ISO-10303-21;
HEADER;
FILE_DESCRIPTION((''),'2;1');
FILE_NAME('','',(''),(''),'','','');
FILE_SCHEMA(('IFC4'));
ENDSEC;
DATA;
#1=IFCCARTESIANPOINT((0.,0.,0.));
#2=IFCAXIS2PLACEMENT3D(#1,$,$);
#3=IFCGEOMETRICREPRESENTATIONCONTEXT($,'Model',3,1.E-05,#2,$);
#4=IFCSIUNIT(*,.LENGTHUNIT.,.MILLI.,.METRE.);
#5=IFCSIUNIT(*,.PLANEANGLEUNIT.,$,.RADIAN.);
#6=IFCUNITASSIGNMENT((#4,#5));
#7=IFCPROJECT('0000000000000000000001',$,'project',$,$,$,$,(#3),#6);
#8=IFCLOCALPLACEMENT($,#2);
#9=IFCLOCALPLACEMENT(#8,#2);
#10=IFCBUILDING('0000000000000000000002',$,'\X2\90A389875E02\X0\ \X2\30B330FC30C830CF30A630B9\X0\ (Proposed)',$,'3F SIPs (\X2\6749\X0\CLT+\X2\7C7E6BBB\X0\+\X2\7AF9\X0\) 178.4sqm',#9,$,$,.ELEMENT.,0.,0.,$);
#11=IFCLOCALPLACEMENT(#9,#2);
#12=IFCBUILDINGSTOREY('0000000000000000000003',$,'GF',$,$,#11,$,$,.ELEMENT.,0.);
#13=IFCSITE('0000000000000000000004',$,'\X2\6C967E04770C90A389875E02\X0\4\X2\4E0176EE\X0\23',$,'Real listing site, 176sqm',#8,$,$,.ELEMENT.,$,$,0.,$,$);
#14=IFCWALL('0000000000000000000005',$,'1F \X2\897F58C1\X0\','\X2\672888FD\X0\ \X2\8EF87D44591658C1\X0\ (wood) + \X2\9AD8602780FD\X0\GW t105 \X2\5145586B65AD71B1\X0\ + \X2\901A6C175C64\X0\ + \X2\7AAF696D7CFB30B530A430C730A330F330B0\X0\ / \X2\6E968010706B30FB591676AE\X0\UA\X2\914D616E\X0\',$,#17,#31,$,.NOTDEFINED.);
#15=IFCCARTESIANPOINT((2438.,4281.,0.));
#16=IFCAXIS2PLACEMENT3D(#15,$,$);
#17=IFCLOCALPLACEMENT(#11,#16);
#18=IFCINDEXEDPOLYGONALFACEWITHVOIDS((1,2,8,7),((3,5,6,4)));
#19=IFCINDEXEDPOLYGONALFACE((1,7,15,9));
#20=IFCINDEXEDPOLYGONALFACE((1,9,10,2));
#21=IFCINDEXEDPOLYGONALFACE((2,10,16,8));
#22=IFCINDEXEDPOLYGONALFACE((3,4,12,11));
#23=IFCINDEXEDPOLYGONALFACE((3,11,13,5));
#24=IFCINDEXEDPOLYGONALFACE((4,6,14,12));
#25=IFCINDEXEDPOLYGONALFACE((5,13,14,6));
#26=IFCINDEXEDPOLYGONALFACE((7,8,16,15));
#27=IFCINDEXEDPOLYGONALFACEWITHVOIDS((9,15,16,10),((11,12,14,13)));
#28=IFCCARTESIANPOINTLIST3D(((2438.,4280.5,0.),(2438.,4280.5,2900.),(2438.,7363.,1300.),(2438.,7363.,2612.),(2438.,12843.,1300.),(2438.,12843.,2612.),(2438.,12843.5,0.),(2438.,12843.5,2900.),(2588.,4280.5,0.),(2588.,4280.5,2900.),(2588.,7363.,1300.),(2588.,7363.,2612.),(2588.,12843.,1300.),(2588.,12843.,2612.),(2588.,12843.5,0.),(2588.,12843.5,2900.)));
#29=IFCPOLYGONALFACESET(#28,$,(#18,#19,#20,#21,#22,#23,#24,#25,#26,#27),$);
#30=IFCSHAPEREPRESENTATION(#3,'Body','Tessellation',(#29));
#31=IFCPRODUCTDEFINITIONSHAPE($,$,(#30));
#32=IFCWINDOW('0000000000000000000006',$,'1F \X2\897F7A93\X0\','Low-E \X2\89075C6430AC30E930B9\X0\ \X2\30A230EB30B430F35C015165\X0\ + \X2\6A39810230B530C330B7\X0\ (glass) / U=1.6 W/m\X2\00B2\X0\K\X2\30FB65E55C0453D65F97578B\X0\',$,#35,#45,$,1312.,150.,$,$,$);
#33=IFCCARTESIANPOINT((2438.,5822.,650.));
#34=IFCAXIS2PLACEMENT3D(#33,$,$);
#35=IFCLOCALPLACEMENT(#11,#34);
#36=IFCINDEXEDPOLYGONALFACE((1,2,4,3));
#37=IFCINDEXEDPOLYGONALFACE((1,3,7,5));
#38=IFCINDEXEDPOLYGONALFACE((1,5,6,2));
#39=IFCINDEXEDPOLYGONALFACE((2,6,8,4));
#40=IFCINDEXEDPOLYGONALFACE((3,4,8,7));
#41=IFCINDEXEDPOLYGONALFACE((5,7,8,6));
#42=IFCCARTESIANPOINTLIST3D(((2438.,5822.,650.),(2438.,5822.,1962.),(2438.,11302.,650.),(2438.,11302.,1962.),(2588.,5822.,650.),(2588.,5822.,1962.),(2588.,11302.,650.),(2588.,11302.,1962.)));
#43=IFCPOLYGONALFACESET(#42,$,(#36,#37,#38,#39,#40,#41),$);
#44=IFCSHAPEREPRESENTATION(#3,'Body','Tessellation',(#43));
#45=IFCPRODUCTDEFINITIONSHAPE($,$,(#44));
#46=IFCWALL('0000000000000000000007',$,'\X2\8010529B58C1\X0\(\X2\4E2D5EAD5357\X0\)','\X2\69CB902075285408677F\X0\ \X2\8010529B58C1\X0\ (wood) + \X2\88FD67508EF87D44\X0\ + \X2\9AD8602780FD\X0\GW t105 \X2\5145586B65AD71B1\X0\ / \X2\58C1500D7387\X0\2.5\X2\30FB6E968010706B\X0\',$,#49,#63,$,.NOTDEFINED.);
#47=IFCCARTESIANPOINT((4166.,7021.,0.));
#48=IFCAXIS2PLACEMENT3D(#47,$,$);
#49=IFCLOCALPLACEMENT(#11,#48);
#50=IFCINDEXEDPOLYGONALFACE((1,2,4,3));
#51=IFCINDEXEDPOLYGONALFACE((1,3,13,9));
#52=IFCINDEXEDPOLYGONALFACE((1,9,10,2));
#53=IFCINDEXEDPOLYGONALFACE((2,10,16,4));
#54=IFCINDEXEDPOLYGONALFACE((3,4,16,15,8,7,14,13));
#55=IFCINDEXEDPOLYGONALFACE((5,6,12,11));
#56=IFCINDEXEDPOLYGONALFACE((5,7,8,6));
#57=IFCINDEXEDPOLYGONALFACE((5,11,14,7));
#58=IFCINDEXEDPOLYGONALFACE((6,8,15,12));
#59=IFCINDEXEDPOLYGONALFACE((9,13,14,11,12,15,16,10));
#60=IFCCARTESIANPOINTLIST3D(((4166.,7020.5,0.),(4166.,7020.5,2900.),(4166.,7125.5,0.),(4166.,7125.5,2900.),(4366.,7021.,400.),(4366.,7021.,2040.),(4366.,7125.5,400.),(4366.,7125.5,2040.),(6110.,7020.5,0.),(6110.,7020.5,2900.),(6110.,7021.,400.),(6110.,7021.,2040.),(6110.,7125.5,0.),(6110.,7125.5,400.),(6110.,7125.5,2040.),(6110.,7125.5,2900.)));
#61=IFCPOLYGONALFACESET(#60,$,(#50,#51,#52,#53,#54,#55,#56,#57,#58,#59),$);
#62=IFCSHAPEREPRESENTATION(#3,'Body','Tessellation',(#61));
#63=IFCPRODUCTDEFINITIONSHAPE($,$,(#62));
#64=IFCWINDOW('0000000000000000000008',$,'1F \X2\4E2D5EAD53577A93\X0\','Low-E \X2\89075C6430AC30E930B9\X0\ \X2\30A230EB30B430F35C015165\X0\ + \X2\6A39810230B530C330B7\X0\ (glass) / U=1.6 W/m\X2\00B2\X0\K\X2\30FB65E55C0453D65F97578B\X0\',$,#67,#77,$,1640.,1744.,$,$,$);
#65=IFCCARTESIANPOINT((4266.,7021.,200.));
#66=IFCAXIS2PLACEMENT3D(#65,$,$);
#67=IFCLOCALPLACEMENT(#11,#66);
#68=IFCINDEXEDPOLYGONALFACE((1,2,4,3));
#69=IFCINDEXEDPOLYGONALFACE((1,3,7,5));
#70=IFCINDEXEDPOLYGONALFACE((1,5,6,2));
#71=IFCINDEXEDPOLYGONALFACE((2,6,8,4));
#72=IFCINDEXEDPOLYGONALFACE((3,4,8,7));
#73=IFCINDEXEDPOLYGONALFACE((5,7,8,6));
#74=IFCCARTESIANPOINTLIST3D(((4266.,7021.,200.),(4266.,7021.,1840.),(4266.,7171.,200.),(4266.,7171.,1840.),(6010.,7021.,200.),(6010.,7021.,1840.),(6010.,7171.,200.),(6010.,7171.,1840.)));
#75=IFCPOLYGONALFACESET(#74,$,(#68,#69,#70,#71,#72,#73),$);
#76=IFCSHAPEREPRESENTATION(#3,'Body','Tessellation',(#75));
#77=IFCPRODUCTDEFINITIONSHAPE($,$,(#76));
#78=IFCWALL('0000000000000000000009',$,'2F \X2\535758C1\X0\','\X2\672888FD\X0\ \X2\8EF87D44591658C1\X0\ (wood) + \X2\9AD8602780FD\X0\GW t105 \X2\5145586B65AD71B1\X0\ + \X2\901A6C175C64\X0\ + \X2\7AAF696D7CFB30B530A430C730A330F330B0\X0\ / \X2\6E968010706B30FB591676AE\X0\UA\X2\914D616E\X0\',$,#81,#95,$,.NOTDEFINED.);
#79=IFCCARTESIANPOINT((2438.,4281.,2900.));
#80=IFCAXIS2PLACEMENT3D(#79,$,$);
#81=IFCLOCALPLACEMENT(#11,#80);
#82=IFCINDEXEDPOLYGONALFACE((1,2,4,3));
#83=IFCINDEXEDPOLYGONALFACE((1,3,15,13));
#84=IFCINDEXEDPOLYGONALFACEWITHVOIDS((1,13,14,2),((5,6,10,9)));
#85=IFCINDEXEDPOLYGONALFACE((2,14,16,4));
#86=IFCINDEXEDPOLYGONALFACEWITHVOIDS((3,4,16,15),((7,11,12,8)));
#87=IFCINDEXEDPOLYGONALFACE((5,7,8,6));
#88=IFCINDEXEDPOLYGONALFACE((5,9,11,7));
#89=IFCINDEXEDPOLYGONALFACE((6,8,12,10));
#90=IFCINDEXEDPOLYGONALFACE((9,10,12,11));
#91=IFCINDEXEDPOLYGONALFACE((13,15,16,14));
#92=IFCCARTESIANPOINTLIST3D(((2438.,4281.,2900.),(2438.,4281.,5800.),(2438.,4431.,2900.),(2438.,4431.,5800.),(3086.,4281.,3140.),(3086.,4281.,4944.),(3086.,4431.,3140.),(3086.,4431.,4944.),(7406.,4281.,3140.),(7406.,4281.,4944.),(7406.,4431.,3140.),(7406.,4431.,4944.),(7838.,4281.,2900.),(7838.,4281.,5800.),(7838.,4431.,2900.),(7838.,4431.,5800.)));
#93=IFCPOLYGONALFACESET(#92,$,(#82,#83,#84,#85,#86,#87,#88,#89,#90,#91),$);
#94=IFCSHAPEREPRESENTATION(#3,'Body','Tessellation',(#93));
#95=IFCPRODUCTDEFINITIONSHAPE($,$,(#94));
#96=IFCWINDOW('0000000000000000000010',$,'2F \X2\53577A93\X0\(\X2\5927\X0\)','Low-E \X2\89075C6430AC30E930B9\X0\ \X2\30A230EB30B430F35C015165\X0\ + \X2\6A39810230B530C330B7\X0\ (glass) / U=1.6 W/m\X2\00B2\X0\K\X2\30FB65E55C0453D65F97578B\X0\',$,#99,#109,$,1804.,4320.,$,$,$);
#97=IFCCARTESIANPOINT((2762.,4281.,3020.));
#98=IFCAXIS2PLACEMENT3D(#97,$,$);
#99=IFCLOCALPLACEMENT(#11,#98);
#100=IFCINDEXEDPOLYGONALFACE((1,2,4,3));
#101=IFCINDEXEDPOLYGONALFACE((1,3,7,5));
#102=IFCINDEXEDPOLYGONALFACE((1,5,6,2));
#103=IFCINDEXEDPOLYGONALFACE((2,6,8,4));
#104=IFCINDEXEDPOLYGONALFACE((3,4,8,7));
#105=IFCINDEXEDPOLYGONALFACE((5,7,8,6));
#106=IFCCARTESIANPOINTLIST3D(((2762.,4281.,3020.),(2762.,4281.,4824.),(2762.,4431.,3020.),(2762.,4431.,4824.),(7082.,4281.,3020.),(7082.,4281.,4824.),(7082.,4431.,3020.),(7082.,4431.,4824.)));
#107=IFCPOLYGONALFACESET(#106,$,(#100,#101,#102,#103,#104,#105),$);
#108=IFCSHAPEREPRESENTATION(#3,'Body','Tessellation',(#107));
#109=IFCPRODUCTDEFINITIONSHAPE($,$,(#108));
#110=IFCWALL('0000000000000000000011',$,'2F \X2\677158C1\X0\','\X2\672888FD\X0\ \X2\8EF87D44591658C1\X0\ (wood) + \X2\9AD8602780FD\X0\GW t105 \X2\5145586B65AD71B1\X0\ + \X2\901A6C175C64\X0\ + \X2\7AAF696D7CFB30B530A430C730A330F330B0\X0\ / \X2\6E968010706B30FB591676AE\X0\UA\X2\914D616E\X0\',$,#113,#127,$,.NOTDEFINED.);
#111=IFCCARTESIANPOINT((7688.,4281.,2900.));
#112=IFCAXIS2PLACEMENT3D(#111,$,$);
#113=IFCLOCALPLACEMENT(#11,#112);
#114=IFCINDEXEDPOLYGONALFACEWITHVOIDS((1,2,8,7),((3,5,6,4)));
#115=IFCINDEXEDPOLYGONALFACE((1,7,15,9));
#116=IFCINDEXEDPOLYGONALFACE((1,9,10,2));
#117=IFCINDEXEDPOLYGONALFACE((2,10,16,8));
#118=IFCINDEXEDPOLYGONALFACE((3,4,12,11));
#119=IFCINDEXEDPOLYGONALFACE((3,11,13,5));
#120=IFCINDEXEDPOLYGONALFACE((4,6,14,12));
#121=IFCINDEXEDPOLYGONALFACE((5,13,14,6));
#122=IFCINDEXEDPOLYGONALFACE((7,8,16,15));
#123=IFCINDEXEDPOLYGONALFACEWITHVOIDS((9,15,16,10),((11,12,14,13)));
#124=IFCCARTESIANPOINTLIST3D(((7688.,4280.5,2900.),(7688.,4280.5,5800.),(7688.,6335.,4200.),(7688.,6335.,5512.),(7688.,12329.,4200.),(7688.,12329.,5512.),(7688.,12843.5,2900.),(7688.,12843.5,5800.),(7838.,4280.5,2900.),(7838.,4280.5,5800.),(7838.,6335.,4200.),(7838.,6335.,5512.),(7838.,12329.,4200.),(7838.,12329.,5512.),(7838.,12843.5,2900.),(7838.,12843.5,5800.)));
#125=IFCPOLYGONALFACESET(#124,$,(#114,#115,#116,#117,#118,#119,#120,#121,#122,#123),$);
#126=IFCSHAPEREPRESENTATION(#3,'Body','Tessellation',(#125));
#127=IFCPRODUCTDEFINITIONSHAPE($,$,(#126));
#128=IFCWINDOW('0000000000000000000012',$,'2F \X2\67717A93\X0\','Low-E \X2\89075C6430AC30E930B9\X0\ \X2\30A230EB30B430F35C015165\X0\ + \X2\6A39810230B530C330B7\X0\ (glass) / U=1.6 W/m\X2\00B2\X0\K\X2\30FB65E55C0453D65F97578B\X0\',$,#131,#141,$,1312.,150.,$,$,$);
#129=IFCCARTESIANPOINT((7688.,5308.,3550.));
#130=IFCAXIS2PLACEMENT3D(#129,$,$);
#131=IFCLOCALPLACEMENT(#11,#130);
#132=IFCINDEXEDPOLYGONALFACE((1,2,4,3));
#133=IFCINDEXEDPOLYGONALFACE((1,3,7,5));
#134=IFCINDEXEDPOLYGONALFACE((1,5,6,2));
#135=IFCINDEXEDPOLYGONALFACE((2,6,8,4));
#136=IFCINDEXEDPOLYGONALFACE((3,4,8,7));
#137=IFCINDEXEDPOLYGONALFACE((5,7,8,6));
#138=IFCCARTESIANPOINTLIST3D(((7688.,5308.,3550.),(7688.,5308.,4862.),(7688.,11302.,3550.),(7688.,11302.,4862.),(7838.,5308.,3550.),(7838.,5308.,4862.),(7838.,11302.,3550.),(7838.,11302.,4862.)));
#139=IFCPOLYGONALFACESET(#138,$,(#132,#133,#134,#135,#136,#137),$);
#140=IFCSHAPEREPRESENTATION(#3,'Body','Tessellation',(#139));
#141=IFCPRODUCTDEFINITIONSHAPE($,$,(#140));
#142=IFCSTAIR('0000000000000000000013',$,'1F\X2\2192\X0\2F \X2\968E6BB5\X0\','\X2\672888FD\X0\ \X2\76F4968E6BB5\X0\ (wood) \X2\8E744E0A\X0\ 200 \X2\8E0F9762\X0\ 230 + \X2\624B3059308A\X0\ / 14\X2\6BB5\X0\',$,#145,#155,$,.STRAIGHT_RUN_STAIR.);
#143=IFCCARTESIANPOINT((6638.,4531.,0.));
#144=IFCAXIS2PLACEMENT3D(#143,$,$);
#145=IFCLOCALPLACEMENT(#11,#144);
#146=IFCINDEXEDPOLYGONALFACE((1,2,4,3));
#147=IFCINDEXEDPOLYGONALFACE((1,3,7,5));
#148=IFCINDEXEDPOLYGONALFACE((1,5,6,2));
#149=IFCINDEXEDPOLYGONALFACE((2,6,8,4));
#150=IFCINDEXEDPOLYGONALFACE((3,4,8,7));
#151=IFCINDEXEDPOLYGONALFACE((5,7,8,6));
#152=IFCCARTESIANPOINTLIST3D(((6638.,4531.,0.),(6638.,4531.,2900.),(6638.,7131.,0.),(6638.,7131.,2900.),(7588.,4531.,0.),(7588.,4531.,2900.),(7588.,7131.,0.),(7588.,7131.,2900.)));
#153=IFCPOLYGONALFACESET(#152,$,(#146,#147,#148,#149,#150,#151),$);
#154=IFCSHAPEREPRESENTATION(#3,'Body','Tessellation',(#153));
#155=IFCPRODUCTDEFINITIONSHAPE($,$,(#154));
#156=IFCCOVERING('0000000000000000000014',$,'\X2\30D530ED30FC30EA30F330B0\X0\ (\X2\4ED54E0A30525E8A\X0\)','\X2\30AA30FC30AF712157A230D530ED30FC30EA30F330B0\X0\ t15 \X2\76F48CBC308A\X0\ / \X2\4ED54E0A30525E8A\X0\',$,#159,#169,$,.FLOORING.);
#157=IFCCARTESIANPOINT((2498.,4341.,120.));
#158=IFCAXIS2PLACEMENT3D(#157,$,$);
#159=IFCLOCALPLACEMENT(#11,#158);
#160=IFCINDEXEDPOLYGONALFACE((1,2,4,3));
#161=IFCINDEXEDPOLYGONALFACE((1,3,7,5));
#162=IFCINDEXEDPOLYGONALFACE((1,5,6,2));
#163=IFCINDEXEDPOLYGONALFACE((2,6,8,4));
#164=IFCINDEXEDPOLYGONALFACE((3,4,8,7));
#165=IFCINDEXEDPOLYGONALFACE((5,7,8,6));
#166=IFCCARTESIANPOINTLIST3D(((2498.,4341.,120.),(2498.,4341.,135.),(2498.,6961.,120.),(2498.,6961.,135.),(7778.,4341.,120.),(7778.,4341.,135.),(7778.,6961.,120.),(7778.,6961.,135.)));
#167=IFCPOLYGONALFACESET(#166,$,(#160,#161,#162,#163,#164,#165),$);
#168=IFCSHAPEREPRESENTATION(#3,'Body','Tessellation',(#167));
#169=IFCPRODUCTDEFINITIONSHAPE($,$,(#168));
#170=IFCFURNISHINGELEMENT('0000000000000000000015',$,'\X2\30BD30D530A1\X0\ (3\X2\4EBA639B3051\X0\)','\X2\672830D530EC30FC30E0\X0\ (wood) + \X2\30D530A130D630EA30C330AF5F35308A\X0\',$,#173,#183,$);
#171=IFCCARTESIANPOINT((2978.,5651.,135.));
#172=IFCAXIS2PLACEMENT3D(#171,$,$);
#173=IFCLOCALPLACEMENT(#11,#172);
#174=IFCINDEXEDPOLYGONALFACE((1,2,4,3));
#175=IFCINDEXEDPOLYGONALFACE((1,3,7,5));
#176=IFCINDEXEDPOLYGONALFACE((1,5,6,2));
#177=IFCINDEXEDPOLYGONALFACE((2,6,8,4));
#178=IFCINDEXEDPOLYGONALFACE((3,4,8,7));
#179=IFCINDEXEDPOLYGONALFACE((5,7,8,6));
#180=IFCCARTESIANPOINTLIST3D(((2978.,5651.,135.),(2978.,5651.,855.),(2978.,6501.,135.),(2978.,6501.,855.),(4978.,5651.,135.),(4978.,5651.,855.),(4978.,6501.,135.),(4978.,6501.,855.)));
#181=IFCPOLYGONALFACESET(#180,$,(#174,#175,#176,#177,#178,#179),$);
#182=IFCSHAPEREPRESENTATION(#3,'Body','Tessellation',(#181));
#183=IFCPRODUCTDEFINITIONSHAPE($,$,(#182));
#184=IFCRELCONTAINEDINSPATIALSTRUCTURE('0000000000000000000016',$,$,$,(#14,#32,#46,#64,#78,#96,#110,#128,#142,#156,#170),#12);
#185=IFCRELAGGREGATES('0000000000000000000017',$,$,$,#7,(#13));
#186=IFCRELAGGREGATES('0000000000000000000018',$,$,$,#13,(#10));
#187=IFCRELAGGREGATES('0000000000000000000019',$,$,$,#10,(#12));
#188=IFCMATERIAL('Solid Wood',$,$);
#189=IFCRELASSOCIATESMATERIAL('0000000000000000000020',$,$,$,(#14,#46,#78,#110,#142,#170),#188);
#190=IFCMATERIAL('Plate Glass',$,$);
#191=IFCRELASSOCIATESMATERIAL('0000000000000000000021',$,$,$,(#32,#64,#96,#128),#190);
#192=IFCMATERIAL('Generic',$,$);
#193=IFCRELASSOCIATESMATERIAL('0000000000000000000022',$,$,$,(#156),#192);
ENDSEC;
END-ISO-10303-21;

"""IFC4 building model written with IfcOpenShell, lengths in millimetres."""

from ifc_helpers import new_model, si_unit, frame, frame_2d, origin, place, context, project, spatial, rectangle, extrude, material, element, fill, save


model = new_model("IFC4")

# Units and contexts
model_context = context("Model", 3, precision=1e-05, world=origin())
ifc_project = project(units=[si_unit("LENGTHUNIT", "METRE", prefix="MILLI"), si_unit("PLANEANGLEUNIT", "RADIAN")], contexts=[model_context])

# Site, building, storey
site_placement = place(None, origin())
site = spatial("IfcSite", under=ifc_project, at=site_placement, Name="沖縄県那覇市4丁目23", ObjectType="Real listing site, 176sqm", CompositionType="ELEMENT", RefElevation=0.0)
building_placement = place(site_placement, origin())
building = spatial("IfcBuilding", under=site, at=building_placement, Name="那覇市 コートハウス (Proposed)", ObjectType="3F SIPs (杉CLT+籾殻+竹) 178.4sqm", CompositionType="ELEMENT", ElevationOfRefHeight=0.0, ElevationOfTerrain=0.0)
storey_placement = place(building_placement, origin())
storey = spatial("IfcBuildingStorey", under=building, at=storey_placement, Name="GF", CompositionType="ELEMENT", Elevation=0.0)

# Shared definitions
ifc_material_1 = material(Name="Solid Wood")
ifc_material_2 = material(Name="Generic")

# Shared definitions
ifc_material_3 = material(Name="Plate Glass")

# Walls, openings, windows
wall_1_placement = place(storey_placement, frame((2438.0, 4281.0, 0.0)))
wall_1 = element("IfcWall", 1, at=wall_1_placement, inside=storey, material=ifc_material_1, Name="1F 西壁", Description="木製 軸組外壁 (wood) + 高性能GW t105 充填断熱 + 通気層 + 窯業系サイディング / 準耐火・外皮UA配慮", PredefinedType="NOTDEFINED", context=model_context, shape_type="SweptSolid", body=[
    extrude(rectangle(XDim=150.0, YDim=8563.0, at=frame_2d((75.0, 4281.0))), frame((2438.0, 4281.0, 0.0)), (0.0, 0.0, 1.0), 2900.0),
])
opening_1_placement = place(storey_placement, frame((2438.0, 5822.0, 650.0)))
opening_1 = element("IfcOpeningElement", 2, at=opening_1_placement, cuts=wall_1, PredefinedType="NOTDEFINED", context=model_context, shape_type="SweptSolid", body=[
    extrude(rectangle(XDim=150.0, YDim=5480.0, at=frame_2d((75.0, 2740.0))), frame((2438.0, 5822.0, 650.0)), (0.0, 0.0, 1.0), 1312.0),
])
window_1_placement = place(storey_placement, frame((2438.0, 5822.0, 650.0)))
window_1 = element("IfcWindow", 3, at=window_1_placement, inside=storey, material=ifc_material_3, Name="1F 西窓", Description="Low-E 複層ガラス アルゴン封入 + 樹脂サッシ (glass) / U=1.6 W/m²K・日射取得型", OverallHeight=1312.0, OverallWidth=150.0, context=model_context, shape_type="SweptSolid", body=[
    extrude(rectangle(XDim=150.0, YDim=5480.0, at=frame_2d((75.0, 2740.0))), frame((2438.0, 5822.0, 650.0)), (0.0, 0.0, 1.0), 1312.0),
])
fill(opening_1, window_1)
wall_2_placement = place(storey_placement, frame((4166.0, 7021.0, 0.0)))
wall_2 = element("IfcWall", 4, at=wall_2_placement, inside=storey, material=ifc_material_1, Name="耐力壁(中庭南)", Description="構造用合板 耐力壁 (wood) + 製材軸組 + 高性能GW t105 充填断熱 / 壁倍率2.5・準耐火", PredefinedType="NOTDEFINED", context=model_context, shape_type="SweptSolid", body=[
    extrude(rectangle(XDim=1944.0, YDim=105.0, at=frame_2d((972.0, 52.0))), frame((4166.0, 7021.0, 0.0)), (0.0, 0.0, 1.0), 2900.0),
])
opening_2_placement = place(storey_placement, frame((4266.0, 7021.0, 200.0)))
opening_2 = element("IfcOpeningElement", 5, at=opening_2_placement, cuts=wall_2, PredefinedType="NOTDEFINED", context=model_context, shape_type="SweptSolid", body=[
    extrude(rectangle(XDim=1744.0, YDim=150.0, at=frame_2d((872.0, 75.0))), frame((4266.0, 7021.0, 200.0)), (0.0, 0.0, 1.0), 1640.0),
])
window_2_placement = place(storey_placement, frame((4266.0, 7021.0, 200.0)))
window_2 = element("IfcWindow", 6, at=window_2_placement, inside=storey, material=ifc_material_3, Name="1F 中庭南窓", Description="Low-E 複層ガラス アルゴン封入 + 樹脂サッシ (glass) / U=1.6 W/m²K・日射取得型", OverallHeight=1640.0, OverallWidth=1744.0, context=model_context, shape_type="SweptSolid", body=[
    extrude(rectangle(XDim=1744.0, YDim=150.0, at=frame_2d((872.0, 75.0))), frame((4266.0, 7021.0, 200.0)), (0.0, 0.0, 1.0), 1640.0),
])
fill(opening_2, window_2)

# Walls, openings, windows
wall_3_placement = place(storey_placement, frame((2438.0, 4281.0, 2900.0)))
wall_3 = element("IfcWall", 7, at=wall_3_placement, inside=storey, material=ifc_material_1, Name="2F 南壁", Description="木製 軸組外壁 (wood) + 高性能GW t105 充填断熱 + 通気層 + 窯業系サイディング / 準耐火・外皮UA配慮", PredefinedType="NOTDEFINED", context=model_context, shape_type="SweptSolid", body=[
    extrude(rectangle(XDim=5400.0, YDim=150.0, at=frame_2d((2700.0, 75.0))), frame((2438.0, 4281.0, 2900.0)), (0.0, 0.0, 1.0), 2900.0),
])
opening_3_placement = place(storey_placement, frame((2762.0, 4281.0, 3020.0)))
opening_3 = element("IfcOpeningElement", 8, at=opening_3_placement, cuts=wall_3, PredefinedType="NOTDEFINED", context=model_context, shape_type="SweptSolid", body=[
    extrude(rectangle(XDim=4320.0, YDim=150.0, at=frame_2d((2160.0, 75.0))), frame((2762.0, 4281.0, 3020.0)), (0.0, 0.0, 1.0), 1804.0),
])
window_3_placement = place(storey_placement, frame((2762.0, 4281.0, 3020.0)))
window_3 = element("IfcWindow", 9, at=window_3_placement, inside=storey, material=ifc_material_3, Name="2F 南窓(大)", Description="Low-E 複層ガラス アルゴン封入 + 樹脂サッシ (glass) / U=1.6 W/m²K・日射取得型", OverallHeight=1804.0, OverallWidth=4320.0, context=model_context, shape_type="SweptSolid", body=[
    extrude(rectangle(XDim=4320.0, YDim=150.0, at=frame_2d((2160.0, 75.0))), frame((2762.0, 4281.0, 3020.0)), (0.0, 0.0, 1.0), 1804.0),
])
fill(opening_3, window_3)
wall_4_placement = place(storey_placement, frame((7688.0, 4281.0, 2900.0)))
wall_4 = element("IfcWall", 10, at=wall_4_placement, inside=storey, material=ifc_material_1, Name="2F 東壁", Description="木製 軸組外壁 (wood) + 高性能GW t105 充填断熱 + 通気層 + 窯業系サイディング / 準耐火・外皮UA配慮", PredefinedType="NOTDEFINED", context=model_context, shape_type="SweptSolid", body=[
    extrude(rectangle(XDim=150.0, YDim=8563.0, at=frame_2d((75.0, 4281.0))), frame((7688.0, 4281.0, 2900.0)), (0.0, 0.0, 1.0), 2900.0),
])
opening_4_placement = place(storey_placement, frame((7688.0, 5308.0, 3550.0)))
opening_4 = element("IfcOpeningElement", 11, at=opening_4_placement, cuts=wall_4, PredefinedType="NOTDEFINED", context=model_context, shape_type="SweptSolid", body=[
    extrude(rectangle(XDim=150.0, YDim=5994.0, at=frame_2d((75.0, 2997.0))), frame((7688.0, 5308.0, 3550.0)), (0.0, 0.0, 1.0), 1312.0),
])
window_4_placement = place(storey_placement, frame((7688.0, 5308.0, 3550.0)))
window_4 = element("IfcWindow", 12, at=window_4_placement, inside=storey, material=ifc_material_3, Name="2F 東窓", Description="Low-E 複層ガラス アルゴン封入 + 樹脂サッシ (glass) / U=1.6 W/m²K・日射取得型", OverallHeight=1312.0, OverallWidth=150.0, context=model_context, shape_type="SweptSolid", body=[
    extrude(rectangle(XDim=150.0, YDim=5994.0, at=frame_2d((75.0, 2997.0))), frame((7688.0, 5308.0, 3550.0)), (0.0, 0.0, 1.0), 1312.0),
])
fill(opening_4, window_4)

# Stair
stair_placement = place(storey_placement, frame((6638.0, 4531.0, 0.0)))
element("IfcStair", 13, at=stair_placement, inside=storey, material=ifc_material_1, Name="1F→2F 階段", Description="木製 直階段 (wood) 蹴上 200 踏面 230 + 手すり / 14段", PredefinedType="STRAIGHT_RUN_STAIR", context=model_context, shape_type="SweptSolid", body=[
    extrude(rectangle(XDim=950.0, YDim=2600.0, at=frame_2d((475.0, 1300.0))), frame((6638.0, 4531.0, 0.0)), (0.0, 0.0, 1.0), 2900.0),
])

# Covering
covering_placement = place(storey_placement, frame((2498.0, 4341.0, 120.0)))
element("IfcCovering", 14, at=covering_placement, inside=storey, material=ifc_material_2, Name="フローリング (仕上げ床)", Description="オーク無垢フローリング t15 直貼り / 仕上げ床", PredefinedType="FLOORING", context=model_context, shape_type="SweptSolid", body=[
    extrude(rectangle(XDim=5280.0, YDim=2620.0, at=frame_2d((2640.0, 1310.0))), frame((2498.0, 4341.0, 120.0)), (0.0, 0.0, 1.0), 15.0),
])

# Furnishing element
furnishing_1_placement = place(storey_placement, frame((2978.0, 5651.0, 135.0)))
element("IfcFurnishingElement", 15, at=furnishing_1_placement, inside=storey, material=ifc_material_1, Name="ソファ (3人掛け)", Description="木フレーム (wood) + ファブリック張り", context=model_context, shape_type="SweptSolid", body=[
    extrude(rectangle(XDim=2000.0, YDim=850.0, at=frame_2d((1000.0, 425.0))), frame((2978.0, 5651.0, 135.0)), (0.0, 0.0, 1.0), 720.0),
])

save(model, "model.ifc")
